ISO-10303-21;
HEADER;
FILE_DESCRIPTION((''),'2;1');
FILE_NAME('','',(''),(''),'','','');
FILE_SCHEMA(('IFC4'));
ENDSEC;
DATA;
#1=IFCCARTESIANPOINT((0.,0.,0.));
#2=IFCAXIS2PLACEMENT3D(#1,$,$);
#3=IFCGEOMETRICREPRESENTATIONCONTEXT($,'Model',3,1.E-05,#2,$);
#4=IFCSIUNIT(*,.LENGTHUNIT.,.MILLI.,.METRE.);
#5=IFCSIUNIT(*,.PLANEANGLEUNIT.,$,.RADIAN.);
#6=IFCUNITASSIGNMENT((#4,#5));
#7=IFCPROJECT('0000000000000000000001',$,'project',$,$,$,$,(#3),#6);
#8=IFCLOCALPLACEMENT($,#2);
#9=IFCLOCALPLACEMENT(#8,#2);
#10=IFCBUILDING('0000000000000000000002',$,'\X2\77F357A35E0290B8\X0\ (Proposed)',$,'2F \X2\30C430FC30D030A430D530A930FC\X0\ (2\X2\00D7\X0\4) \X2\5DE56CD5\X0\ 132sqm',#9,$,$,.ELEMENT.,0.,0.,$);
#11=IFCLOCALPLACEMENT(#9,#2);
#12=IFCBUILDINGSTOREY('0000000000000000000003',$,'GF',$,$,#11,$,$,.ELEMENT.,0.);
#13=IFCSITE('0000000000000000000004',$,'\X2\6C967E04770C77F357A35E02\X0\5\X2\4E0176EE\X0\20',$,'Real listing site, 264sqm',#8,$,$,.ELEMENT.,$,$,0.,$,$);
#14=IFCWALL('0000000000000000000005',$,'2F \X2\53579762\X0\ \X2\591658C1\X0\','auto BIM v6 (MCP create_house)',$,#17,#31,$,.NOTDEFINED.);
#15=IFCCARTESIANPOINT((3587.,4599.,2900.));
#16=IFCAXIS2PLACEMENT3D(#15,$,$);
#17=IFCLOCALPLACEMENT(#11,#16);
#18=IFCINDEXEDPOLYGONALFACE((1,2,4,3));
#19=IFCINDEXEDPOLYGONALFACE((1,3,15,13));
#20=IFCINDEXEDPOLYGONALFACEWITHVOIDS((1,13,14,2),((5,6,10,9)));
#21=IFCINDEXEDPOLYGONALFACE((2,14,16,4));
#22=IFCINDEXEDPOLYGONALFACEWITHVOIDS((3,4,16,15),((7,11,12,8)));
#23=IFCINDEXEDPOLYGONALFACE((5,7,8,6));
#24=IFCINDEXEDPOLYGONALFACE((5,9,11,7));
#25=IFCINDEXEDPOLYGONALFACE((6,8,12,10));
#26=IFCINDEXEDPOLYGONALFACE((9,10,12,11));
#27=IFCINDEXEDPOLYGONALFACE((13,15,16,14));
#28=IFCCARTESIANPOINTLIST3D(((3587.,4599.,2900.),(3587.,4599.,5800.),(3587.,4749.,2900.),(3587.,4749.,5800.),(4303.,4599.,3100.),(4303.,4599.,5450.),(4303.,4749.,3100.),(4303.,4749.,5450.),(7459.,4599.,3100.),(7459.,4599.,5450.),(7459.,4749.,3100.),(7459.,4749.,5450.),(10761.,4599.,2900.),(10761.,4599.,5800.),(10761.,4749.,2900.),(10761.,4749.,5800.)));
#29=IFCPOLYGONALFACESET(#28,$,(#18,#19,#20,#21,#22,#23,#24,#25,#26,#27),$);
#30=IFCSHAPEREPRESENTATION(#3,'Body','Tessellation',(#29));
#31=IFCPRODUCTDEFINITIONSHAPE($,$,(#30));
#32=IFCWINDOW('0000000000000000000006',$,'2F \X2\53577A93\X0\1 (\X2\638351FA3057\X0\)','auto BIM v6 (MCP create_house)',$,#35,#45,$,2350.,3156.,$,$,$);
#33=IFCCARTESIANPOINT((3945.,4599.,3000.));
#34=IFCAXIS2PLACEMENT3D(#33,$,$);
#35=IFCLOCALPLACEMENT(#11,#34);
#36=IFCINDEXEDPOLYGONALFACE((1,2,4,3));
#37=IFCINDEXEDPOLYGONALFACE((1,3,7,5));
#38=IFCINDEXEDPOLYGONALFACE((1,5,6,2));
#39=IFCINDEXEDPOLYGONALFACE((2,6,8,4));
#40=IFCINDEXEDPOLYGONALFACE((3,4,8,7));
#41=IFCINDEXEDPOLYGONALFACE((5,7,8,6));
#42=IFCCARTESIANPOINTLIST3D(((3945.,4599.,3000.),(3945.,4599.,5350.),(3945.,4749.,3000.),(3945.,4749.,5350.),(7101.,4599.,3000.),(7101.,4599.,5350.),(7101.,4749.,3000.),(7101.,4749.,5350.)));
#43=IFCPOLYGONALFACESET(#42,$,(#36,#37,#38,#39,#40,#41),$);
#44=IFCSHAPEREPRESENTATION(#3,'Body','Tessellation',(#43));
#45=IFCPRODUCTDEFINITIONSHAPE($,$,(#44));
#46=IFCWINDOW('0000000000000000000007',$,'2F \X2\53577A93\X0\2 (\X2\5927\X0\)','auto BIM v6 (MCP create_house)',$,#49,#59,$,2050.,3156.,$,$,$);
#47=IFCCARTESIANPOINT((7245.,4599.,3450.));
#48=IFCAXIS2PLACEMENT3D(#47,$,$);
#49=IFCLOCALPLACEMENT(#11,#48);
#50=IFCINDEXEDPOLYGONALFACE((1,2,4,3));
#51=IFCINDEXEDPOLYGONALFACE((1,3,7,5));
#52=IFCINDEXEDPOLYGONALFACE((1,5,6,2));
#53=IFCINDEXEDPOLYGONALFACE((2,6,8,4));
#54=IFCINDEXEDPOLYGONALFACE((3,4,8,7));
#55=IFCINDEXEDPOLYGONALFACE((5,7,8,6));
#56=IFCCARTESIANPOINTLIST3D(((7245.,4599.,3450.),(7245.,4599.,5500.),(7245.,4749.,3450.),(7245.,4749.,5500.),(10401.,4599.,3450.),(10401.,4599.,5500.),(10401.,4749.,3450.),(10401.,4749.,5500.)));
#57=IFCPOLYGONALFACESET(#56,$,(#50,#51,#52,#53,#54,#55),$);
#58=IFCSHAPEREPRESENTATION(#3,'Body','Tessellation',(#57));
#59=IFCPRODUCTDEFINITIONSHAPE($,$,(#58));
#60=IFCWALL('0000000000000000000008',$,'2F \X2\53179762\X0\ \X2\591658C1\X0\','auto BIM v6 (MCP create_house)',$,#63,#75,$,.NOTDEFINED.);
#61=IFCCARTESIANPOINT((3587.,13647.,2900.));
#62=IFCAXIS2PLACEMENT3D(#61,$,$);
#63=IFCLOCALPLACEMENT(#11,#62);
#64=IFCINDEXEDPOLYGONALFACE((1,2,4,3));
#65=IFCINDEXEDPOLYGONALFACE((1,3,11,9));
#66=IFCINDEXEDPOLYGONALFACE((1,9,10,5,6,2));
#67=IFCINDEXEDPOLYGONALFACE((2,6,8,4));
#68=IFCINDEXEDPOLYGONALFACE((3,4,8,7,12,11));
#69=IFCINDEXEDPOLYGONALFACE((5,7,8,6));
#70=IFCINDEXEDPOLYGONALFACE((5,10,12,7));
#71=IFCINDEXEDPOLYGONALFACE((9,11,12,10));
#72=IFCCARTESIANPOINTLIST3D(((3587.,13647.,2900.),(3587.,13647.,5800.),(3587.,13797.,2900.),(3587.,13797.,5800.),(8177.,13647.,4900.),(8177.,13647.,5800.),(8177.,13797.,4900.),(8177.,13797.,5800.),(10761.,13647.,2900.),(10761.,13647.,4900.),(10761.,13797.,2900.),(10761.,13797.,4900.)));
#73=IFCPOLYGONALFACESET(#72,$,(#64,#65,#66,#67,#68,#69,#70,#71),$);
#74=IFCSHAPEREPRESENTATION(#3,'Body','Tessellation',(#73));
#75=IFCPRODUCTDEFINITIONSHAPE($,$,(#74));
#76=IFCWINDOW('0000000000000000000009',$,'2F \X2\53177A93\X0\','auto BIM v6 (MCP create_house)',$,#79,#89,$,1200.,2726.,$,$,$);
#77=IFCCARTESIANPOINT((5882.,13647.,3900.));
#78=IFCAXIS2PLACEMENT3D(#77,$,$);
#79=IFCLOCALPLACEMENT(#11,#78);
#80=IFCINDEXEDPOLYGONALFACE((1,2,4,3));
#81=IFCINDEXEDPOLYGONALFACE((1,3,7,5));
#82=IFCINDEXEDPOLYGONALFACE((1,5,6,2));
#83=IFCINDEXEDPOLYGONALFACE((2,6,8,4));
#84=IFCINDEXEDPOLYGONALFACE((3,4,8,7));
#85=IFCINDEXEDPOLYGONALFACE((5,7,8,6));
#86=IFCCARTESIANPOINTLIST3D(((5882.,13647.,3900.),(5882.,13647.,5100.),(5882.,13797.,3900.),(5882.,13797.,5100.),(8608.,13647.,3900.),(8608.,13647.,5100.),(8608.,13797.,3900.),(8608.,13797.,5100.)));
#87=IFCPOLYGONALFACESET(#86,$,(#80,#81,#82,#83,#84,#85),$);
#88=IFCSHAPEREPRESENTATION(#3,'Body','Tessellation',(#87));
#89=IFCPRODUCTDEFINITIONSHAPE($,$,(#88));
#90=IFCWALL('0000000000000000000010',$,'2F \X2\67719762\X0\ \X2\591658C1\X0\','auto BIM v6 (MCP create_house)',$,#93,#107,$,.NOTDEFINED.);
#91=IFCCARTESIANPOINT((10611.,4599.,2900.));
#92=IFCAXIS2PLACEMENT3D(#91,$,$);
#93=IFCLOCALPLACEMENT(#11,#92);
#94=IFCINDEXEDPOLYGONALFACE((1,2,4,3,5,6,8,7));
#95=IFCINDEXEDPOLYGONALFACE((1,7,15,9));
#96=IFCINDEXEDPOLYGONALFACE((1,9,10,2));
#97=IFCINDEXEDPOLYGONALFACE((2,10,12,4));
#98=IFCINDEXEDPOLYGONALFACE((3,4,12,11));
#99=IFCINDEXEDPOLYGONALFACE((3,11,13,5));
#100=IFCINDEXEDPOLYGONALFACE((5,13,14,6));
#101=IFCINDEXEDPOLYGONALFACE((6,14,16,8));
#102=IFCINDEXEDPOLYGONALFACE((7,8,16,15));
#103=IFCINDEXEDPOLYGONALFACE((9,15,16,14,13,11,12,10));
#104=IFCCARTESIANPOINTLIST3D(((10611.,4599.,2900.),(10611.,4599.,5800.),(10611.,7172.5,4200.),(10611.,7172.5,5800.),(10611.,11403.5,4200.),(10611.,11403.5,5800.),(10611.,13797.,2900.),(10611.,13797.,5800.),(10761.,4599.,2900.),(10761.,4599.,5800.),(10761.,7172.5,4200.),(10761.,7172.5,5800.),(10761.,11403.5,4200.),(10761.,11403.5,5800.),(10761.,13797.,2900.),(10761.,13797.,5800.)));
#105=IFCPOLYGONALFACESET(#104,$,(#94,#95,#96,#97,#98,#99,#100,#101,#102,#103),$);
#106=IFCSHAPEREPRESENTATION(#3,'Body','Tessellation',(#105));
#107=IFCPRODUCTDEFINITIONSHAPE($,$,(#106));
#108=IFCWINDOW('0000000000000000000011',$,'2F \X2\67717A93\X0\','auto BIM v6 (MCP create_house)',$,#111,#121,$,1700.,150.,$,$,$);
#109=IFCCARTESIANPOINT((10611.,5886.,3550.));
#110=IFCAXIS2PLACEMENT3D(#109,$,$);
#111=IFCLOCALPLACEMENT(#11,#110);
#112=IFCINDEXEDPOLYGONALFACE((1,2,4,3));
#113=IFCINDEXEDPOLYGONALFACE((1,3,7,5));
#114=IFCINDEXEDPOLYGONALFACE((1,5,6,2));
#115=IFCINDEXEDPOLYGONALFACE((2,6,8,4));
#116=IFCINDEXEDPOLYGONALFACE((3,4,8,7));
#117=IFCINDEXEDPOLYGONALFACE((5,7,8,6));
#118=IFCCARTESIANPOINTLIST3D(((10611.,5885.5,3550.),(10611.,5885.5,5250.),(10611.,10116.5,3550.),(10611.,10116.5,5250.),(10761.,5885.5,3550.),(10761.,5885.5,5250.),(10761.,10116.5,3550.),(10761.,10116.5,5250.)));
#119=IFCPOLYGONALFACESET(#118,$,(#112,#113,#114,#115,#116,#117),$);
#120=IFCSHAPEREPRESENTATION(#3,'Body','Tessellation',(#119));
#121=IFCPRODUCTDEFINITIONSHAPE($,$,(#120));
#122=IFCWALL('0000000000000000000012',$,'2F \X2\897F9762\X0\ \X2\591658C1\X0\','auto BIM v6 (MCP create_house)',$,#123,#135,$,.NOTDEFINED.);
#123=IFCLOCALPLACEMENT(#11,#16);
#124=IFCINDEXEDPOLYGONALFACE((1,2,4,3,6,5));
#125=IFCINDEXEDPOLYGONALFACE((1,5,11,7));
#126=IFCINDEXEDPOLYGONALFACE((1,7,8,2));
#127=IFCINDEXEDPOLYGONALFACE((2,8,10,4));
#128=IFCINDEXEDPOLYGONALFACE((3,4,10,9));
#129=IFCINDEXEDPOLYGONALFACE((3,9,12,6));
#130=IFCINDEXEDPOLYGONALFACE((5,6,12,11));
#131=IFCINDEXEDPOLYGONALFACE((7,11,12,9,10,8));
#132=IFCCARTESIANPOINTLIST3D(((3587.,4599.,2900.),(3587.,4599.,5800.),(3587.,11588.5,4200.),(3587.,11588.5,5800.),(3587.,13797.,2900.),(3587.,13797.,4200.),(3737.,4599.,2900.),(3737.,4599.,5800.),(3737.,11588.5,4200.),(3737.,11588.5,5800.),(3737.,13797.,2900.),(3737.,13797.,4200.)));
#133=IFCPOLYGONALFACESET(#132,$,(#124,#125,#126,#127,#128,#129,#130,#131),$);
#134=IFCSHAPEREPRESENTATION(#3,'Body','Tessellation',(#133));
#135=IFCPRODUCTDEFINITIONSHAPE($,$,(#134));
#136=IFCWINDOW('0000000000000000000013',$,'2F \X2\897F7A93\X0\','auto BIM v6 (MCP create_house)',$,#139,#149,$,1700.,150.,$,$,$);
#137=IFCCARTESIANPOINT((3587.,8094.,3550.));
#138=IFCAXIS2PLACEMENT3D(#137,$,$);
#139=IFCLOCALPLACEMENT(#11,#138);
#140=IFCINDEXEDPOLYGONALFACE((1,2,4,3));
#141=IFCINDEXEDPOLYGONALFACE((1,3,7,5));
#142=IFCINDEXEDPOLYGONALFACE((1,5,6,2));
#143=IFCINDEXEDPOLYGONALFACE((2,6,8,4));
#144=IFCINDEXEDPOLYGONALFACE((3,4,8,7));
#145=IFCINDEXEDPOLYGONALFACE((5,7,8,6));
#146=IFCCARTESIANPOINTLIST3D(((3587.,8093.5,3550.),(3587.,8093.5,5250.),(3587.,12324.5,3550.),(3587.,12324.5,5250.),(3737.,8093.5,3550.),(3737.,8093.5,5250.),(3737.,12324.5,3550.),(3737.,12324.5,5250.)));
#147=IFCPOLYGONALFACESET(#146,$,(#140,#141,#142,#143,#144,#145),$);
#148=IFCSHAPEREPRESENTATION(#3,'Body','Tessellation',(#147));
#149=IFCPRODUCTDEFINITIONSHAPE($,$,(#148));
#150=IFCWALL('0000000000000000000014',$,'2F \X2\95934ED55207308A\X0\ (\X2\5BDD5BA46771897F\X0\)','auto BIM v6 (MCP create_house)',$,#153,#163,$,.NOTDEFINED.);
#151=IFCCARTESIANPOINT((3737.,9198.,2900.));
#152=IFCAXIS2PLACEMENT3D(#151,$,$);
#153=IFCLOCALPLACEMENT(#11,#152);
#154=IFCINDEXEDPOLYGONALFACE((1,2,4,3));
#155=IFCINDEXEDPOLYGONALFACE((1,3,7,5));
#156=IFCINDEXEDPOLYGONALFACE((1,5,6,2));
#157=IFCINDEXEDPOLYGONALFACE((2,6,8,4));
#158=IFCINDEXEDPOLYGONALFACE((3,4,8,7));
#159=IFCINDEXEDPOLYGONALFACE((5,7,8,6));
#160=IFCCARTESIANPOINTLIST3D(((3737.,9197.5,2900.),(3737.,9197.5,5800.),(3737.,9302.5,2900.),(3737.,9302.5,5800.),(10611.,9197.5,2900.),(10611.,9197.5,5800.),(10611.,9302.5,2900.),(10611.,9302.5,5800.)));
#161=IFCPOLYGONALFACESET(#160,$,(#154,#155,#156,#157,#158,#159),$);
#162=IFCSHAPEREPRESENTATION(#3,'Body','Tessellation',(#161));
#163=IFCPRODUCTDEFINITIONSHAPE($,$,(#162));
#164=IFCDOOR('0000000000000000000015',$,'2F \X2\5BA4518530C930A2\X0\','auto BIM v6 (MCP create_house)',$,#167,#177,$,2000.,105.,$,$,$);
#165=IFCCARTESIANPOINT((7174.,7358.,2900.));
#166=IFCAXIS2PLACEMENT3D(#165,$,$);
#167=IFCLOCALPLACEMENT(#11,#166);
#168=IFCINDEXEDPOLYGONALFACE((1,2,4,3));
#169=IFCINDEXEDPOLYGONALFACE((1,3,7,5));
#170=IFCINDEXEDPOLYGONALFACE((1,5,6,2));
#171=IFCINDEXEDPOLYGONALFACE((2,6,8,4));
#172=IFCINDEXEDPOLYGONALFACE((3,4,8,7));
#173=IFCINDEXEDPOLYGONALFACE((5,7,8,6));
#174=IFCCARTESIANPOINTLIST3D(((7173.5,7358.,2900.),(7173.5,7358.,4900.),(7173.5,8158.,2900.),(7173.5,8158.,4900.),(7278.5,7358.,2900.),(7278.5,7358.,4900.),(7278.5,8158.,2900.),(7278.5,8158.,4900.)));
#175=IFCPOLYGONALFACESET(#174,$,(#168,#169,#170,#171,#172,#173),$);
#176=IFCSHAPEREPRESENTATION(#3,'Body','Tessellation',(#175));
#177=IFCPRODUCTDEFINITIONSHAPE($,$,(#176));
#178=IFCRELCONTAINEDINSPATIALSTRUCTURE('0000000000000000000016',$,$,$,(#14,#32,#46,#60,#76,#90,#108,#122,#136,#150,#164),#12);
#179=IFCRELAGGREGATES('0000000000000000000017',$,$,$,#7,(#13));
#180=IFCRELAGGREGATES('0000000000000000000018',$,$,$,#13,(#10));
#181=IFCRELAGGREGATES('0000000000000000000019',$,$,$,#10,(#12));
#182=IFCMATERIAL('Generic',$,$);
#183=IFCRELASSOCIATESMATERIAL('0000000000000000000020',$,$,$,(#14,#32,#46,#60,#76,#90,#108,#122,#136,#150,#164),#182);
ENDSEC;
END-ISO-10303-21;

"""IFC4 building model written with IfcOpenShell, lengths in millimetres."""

from ifc_helpers import new_model, si_unit, frame, frame_2d, origin, place, context, project, spatial, rectangle, extrude, material, element, fill, save


model = new_model("IFC4")

# Units and contexts
model_context = context("Model", 3, precision=1e-05, world=origin())
ifc_project = project(units=[si_unit("LENGTHUNIT", "METRE", prefix="MILLI"), si_unit("PLANEANGLEUNIT", "RADIAN")], contexts=[model_context])

# Site, building, storey
site_placement = place(None, origin())
site = spatial("IfcSite", under=ifc_project, at=site_placement, Name="沖縄県石垣市5丁目20", ObjectType="Real listing site, 264sqm", CompositionType="ELEMENT", RefElevation=0.0)
building_placement = place(site_placement, origin())
building = spatial("IfcBuilding", under=site, at=building_placement, Name="石垣市邸 (Proposed)", ObjectType="2F ツーバイフォー (2×4) 工法 132sqm", CompositionType="ELEMENT", ElevationOfRefHeight=0.0, ElevationOfTerrain=0.0)
storey_placement = place(building_placement, origin())
storey = spatial("IfcBuildingStorey", under=building, at=storey_placement, Name="GF", CompositionType="ELEMENT", Elevation=0.0)

# Shared definitions
ifc_material = material(Name="Generic")

# Wall, openings, windows
wall_1_placement = place(storey_placement, frame((3587.0, 4599.0, 2900.0)))
wall_1 = element("IfcWall", 1, at=wall_1_placement, inside=storey, material=ifc_material, Name="2F 南面 外壁", Description="auto BIM v6 (MCP create_house)", PredefinedType="NOTDEFINED", context=model_context, shape_type="SweptSolid", body=[
    extrude(rectangle(XDim=7174.0, YDim=150.0, at=frame_2d((3587.0, 75.0))), frame((3587.0, 4599.0, 2900.0)), (0.0, 0.0, 1.0), 2900.0),
])
opening_1_placement = place(storey_placement, frame((3945.0, 4599.0, 3000.0)))
opening_1 = element("IfcOpeningElement", 2, at=opening_1_placement, cuts=wall_1, PredefinedType="NOTDEFINED", context=model_context, shape_type="SweptSolid", body=[
    extrude(rectangle(XDim=3156.0, YDim=150.0, at=frame_2d((1578.0, 75.0))), frame((3945.0, 4599.0, 3000.0)), (0.0, 0.0, 1.0), 2350.0),
])
opening_2_placement = place(storey_placement, frame((7245.0, 4599.0, 3450.0)))
opening_2 = element("IfcOpeningElement", 3, at=opening_2_placement, cuts=wall_1, PredefinedType="NOTDEFINED", context=model_context, shape_type="SweptSolid", body=[
    extrude(rectangle(XDim=3156.0, YDim=150.0, at=frame_2d((1578.0, 75.0))), frame((7245.0, 4599.0, 3450.0)), (0.0, 0.0, 1.0), 2050.0),
])
window_1_placement = place(storey_placement, frame((3945.0, 4599.0, 3000.0)))
window_1 = element("IfcWindow", 4, at=window_1_placement, inside=storey, material=ifc_material, Name="2F 南窓1 (掃出し)", Description="auto BIM v6 (MCP create_house)", OverallHeight=2350.0, OverallWidth=3156.0, context=model_context, shape_type="SweptSolid", body=[
    extrude(rectangle(XDim=3156.0, YDim=150.0, at=frame_2d((1578.0, 75.0))), frame((3945.0, 4599.0, 3000.0)), (0.0, 0.0, 1.0), 2350.0),
])
fill(opening_1, window_1)
window_2_placement = place(storey_placement, frame((7245.0, 4599.0, 3450.0)))
window_2 = element("IfcWindow", 5, at=window_2_placement, inside=storey, material=ifc_material, Name="2F 南窓2 (大)", Description="auto BIM v6 (MCP create_house)", OverallHeight=2050.0, OverallWidth=3156.0, context=model_context, shape_type="SweptSolid", body=[
    extrude(rectangle(XDim=3156.0, YDim=150.0, at=frame_2d((1578.0, 75.0))), frame((7245.0, 4599.0, 3450.0)), (0.0, 0.0, 1.0), 2050.0),
])
fill(opening_2, window_2)

# Walls, openings, windows
wall_2_placement = place(storey_placement, frame((3587.0, 13647.0, 2900.0)))
wall_2 = element("IfcWall", 6, at=wall_2_placement, inside=storey, material=ifc_material, Name="2F 北面 外壁", Description="auto BIM v6 (MCP create_house)", PredefinedType="NOTDEFINED", context=model_context, shape_type="SweptSolid", body=[
    extrude(rectangle(XDim=7174.0, YDim=150.0, at=frame_2d((3587.0, 75.0))), frame((3587.0, 13647.0, 2900.0)), (0.0, 0.0, 1.0), 2900.0),
])
opening_3_placement = place(storey_placement, frame((5882.0, 13647.0, 3900.0)))
opening_3 = element("IfcOpeningElement", 7, at=opening_3_placement, cuts=wall_2, PredefinedType="NOTDEFINED", context=model_context, shape_type="SweptSolid", body=[
    extrude(rectangle(XDim=2726.0, YDim=150.0, at=frame_2d((1363.0, 75.0))), frame((5882.0, 13647.0, 3900.0)), (0.0, 0.0, 1.0), 1200.0),
])
window_3_placement = place(storey_placement, frame((5882.0, 13647.0, 3900.0)))
window_3 = element("IfcWindow", 8, at=window_3_placement, inside=storey, material=ifc_material, Name="2F 北窓", Description="auto BIM v6 (MCP create_house)", OverallHeight=1200.0, OverallWidth=2726.0, context=model_context, shape_type="SweptSolid", body=[
    extrude(rectangle(XDim=2726.0, YDim=150.0, at=frame_2d((1363.0, 75.0))), frame((5882.0, 13647.0, 3900.0)), (0.0, 0.0, 1.0), 1200.0),
])
fill(opening_3, window_3)
wall_3_placement = place(storey_placement, frame((10611.0, 4599.0, 2900.0)))
wall_3 = element("IfcWall", 9, at=wall_3_placement, inside=storey, material=ifc_material, Name="2F 東面 外壁", Description="auto BIM v6 (MCP create_house)", PredefinedType="NOTDEFINED", context=model_context, shape_type="SweptSolid", body=[
    extrude(rectangle(XDim=150.0, YDim=9198.0, at=frame_2d((75.0, 4599.0))), frame((10611.0, 4599.0, 2900.0)), (0.0, 0.0, 1.0), 2900.0),
])
opening_4_placement = place(storey_placement, frame((10611.0, 5886.0, 3550.0)))
opening_4 = element("IfcOpeningElement", 10, at=opening_4_placement, cuts=wall_3, PredefinedType="NOTDEFINED", context=model_context, shape_type="SweptSolid", body=[
    extrude(rectangle(XDim=150.0, YDim=4231.0, at=frame_2d((75.0, 2115.0))), frame((10611.0, 5886.0, 3550.0)), (0.0, 0.0, 1.0), 1700.0),
])
window_4_placement = place(storey_placement, frame((10611.0, 5886.0, 3550.0)))
window_4 = element("IfcWindow", 11, at=window_4_placement, inside=storey, material=ifc_material, Name="2F 東窓", Description="auto BIM v6 (MCP create_house)", OverallHeight=1700.0, OverallWidth=150.0, context=model_context, shape_type="SweptSolid", body=[
    extrude(rectangle(XDim=150.0, YDim=4231.0, at=frame_2d((75.0, 2115.0))), frame((10611.0, 5886.0, 3550.0)), (0.0, 0.0, 1.0), 1700.0),
])
fill(opening_4, window_4)
wall_4_placement = place(storey_placement, frame((3587.0, 4599.0, 2900.0)))
wall_4 = element("IfcWall", 12, at=wall_4_placement, inside=storey, material=ifc_material, Name="2F 西面 外壁", Description="auto BIM v6 (MCP create_house)", PredefinedType="NOTDEFINED", context=model_context, shape_type="SweptSolid", body=[
    extrude(rectangle(XDim=150.0, YDim=9198.0, at=frame_2d((75.0, 4599.0))), frame((3587.0, 4599.0, 2900.0)), (0.0, 0.0, 1.0), 2900.0),
])
opening_5_placement = place(storey_placement, frame((3587.0, 8094.0, 3550.0)))
opening_5 = element("IfcOpeningElement", 13, at=opening_5_placement, cuts=wall_4, PredefinedType="NOTDEFINED", context=model_context, shape_type="SweptSolid", body=[
    extrude(rectangle(XDim=150.0, YDim=4231.0, at=frame_2d((75.0, 2115.0))), frame((3587.0, 8094.0, 3550.0)), (0.0, 0.0, 1.0), 1700.0),
])
window_5_placement = place(storey_placement, frame((3587.0, 8094.0, 3550.0)))
window_5 = element("IfcWindow", 14, at=window_5_placement, inside=storey, material=ifc_material, Name="2F 西窓", Description="auto BIM v6 (MCP create_house)", OverallHeight=1700.0, OverallWidth=150.0, context=model_context, shape_type="SweptSolid", body=[
    extrude(rectangle(XDim=150.0, YDim=4231.0, at=frame_2d((75.0, 2115.0))), frame((3587.0, 8094.0, 3550.0)), (0.0, 0.0, 1.0), 1700.0),
])
fill(opening_5, window_5)

# Wall
wall_5_placement = place(storey_placement, frame((3737.0, 9198.0, 2900.0)))
element("IfcWall", 15, at=wall_5_placement, inside=storey, material=ifc_material, Name="2F 間仕切り (寝室東西)", Description="auto BIM v6 (MCP create_house)", PredefinedType="NOTDEFINED", context=model_context, shape_type="SweptSolid", body=[
    extrude(rectangle(XDim=6874.0, YDim=105.0, at=frame_2d((3437.0, 52.0))), frame((3737.0, 9198.0, 2900.0)), (0.0, 0.0, 1.0), 2900.0),
])

# Door
door_1_placement = place(storey_placement, frame((7174.0, 7358.0, 2900.0)))
element("IfcDoor", 16, at=door_1_placement, inside=storey, material=ifc_material, Name="2F 室内ドア", Description="auto BIM v6 (MCP create_house)", OverallHeight=2000.0, OverallWidth=105.0, context=model_context, shape_type="SweptSolid", body=[
    extrude(rectangle(XDim=105.0, YDim=800.0, at=frame_2d((52.0, 400.0))), frame((7174.0, 7358.0, 2900.0)), (0.0, 0.0, 1.0), 2000.0),
])

save(model, "model.ifc")
